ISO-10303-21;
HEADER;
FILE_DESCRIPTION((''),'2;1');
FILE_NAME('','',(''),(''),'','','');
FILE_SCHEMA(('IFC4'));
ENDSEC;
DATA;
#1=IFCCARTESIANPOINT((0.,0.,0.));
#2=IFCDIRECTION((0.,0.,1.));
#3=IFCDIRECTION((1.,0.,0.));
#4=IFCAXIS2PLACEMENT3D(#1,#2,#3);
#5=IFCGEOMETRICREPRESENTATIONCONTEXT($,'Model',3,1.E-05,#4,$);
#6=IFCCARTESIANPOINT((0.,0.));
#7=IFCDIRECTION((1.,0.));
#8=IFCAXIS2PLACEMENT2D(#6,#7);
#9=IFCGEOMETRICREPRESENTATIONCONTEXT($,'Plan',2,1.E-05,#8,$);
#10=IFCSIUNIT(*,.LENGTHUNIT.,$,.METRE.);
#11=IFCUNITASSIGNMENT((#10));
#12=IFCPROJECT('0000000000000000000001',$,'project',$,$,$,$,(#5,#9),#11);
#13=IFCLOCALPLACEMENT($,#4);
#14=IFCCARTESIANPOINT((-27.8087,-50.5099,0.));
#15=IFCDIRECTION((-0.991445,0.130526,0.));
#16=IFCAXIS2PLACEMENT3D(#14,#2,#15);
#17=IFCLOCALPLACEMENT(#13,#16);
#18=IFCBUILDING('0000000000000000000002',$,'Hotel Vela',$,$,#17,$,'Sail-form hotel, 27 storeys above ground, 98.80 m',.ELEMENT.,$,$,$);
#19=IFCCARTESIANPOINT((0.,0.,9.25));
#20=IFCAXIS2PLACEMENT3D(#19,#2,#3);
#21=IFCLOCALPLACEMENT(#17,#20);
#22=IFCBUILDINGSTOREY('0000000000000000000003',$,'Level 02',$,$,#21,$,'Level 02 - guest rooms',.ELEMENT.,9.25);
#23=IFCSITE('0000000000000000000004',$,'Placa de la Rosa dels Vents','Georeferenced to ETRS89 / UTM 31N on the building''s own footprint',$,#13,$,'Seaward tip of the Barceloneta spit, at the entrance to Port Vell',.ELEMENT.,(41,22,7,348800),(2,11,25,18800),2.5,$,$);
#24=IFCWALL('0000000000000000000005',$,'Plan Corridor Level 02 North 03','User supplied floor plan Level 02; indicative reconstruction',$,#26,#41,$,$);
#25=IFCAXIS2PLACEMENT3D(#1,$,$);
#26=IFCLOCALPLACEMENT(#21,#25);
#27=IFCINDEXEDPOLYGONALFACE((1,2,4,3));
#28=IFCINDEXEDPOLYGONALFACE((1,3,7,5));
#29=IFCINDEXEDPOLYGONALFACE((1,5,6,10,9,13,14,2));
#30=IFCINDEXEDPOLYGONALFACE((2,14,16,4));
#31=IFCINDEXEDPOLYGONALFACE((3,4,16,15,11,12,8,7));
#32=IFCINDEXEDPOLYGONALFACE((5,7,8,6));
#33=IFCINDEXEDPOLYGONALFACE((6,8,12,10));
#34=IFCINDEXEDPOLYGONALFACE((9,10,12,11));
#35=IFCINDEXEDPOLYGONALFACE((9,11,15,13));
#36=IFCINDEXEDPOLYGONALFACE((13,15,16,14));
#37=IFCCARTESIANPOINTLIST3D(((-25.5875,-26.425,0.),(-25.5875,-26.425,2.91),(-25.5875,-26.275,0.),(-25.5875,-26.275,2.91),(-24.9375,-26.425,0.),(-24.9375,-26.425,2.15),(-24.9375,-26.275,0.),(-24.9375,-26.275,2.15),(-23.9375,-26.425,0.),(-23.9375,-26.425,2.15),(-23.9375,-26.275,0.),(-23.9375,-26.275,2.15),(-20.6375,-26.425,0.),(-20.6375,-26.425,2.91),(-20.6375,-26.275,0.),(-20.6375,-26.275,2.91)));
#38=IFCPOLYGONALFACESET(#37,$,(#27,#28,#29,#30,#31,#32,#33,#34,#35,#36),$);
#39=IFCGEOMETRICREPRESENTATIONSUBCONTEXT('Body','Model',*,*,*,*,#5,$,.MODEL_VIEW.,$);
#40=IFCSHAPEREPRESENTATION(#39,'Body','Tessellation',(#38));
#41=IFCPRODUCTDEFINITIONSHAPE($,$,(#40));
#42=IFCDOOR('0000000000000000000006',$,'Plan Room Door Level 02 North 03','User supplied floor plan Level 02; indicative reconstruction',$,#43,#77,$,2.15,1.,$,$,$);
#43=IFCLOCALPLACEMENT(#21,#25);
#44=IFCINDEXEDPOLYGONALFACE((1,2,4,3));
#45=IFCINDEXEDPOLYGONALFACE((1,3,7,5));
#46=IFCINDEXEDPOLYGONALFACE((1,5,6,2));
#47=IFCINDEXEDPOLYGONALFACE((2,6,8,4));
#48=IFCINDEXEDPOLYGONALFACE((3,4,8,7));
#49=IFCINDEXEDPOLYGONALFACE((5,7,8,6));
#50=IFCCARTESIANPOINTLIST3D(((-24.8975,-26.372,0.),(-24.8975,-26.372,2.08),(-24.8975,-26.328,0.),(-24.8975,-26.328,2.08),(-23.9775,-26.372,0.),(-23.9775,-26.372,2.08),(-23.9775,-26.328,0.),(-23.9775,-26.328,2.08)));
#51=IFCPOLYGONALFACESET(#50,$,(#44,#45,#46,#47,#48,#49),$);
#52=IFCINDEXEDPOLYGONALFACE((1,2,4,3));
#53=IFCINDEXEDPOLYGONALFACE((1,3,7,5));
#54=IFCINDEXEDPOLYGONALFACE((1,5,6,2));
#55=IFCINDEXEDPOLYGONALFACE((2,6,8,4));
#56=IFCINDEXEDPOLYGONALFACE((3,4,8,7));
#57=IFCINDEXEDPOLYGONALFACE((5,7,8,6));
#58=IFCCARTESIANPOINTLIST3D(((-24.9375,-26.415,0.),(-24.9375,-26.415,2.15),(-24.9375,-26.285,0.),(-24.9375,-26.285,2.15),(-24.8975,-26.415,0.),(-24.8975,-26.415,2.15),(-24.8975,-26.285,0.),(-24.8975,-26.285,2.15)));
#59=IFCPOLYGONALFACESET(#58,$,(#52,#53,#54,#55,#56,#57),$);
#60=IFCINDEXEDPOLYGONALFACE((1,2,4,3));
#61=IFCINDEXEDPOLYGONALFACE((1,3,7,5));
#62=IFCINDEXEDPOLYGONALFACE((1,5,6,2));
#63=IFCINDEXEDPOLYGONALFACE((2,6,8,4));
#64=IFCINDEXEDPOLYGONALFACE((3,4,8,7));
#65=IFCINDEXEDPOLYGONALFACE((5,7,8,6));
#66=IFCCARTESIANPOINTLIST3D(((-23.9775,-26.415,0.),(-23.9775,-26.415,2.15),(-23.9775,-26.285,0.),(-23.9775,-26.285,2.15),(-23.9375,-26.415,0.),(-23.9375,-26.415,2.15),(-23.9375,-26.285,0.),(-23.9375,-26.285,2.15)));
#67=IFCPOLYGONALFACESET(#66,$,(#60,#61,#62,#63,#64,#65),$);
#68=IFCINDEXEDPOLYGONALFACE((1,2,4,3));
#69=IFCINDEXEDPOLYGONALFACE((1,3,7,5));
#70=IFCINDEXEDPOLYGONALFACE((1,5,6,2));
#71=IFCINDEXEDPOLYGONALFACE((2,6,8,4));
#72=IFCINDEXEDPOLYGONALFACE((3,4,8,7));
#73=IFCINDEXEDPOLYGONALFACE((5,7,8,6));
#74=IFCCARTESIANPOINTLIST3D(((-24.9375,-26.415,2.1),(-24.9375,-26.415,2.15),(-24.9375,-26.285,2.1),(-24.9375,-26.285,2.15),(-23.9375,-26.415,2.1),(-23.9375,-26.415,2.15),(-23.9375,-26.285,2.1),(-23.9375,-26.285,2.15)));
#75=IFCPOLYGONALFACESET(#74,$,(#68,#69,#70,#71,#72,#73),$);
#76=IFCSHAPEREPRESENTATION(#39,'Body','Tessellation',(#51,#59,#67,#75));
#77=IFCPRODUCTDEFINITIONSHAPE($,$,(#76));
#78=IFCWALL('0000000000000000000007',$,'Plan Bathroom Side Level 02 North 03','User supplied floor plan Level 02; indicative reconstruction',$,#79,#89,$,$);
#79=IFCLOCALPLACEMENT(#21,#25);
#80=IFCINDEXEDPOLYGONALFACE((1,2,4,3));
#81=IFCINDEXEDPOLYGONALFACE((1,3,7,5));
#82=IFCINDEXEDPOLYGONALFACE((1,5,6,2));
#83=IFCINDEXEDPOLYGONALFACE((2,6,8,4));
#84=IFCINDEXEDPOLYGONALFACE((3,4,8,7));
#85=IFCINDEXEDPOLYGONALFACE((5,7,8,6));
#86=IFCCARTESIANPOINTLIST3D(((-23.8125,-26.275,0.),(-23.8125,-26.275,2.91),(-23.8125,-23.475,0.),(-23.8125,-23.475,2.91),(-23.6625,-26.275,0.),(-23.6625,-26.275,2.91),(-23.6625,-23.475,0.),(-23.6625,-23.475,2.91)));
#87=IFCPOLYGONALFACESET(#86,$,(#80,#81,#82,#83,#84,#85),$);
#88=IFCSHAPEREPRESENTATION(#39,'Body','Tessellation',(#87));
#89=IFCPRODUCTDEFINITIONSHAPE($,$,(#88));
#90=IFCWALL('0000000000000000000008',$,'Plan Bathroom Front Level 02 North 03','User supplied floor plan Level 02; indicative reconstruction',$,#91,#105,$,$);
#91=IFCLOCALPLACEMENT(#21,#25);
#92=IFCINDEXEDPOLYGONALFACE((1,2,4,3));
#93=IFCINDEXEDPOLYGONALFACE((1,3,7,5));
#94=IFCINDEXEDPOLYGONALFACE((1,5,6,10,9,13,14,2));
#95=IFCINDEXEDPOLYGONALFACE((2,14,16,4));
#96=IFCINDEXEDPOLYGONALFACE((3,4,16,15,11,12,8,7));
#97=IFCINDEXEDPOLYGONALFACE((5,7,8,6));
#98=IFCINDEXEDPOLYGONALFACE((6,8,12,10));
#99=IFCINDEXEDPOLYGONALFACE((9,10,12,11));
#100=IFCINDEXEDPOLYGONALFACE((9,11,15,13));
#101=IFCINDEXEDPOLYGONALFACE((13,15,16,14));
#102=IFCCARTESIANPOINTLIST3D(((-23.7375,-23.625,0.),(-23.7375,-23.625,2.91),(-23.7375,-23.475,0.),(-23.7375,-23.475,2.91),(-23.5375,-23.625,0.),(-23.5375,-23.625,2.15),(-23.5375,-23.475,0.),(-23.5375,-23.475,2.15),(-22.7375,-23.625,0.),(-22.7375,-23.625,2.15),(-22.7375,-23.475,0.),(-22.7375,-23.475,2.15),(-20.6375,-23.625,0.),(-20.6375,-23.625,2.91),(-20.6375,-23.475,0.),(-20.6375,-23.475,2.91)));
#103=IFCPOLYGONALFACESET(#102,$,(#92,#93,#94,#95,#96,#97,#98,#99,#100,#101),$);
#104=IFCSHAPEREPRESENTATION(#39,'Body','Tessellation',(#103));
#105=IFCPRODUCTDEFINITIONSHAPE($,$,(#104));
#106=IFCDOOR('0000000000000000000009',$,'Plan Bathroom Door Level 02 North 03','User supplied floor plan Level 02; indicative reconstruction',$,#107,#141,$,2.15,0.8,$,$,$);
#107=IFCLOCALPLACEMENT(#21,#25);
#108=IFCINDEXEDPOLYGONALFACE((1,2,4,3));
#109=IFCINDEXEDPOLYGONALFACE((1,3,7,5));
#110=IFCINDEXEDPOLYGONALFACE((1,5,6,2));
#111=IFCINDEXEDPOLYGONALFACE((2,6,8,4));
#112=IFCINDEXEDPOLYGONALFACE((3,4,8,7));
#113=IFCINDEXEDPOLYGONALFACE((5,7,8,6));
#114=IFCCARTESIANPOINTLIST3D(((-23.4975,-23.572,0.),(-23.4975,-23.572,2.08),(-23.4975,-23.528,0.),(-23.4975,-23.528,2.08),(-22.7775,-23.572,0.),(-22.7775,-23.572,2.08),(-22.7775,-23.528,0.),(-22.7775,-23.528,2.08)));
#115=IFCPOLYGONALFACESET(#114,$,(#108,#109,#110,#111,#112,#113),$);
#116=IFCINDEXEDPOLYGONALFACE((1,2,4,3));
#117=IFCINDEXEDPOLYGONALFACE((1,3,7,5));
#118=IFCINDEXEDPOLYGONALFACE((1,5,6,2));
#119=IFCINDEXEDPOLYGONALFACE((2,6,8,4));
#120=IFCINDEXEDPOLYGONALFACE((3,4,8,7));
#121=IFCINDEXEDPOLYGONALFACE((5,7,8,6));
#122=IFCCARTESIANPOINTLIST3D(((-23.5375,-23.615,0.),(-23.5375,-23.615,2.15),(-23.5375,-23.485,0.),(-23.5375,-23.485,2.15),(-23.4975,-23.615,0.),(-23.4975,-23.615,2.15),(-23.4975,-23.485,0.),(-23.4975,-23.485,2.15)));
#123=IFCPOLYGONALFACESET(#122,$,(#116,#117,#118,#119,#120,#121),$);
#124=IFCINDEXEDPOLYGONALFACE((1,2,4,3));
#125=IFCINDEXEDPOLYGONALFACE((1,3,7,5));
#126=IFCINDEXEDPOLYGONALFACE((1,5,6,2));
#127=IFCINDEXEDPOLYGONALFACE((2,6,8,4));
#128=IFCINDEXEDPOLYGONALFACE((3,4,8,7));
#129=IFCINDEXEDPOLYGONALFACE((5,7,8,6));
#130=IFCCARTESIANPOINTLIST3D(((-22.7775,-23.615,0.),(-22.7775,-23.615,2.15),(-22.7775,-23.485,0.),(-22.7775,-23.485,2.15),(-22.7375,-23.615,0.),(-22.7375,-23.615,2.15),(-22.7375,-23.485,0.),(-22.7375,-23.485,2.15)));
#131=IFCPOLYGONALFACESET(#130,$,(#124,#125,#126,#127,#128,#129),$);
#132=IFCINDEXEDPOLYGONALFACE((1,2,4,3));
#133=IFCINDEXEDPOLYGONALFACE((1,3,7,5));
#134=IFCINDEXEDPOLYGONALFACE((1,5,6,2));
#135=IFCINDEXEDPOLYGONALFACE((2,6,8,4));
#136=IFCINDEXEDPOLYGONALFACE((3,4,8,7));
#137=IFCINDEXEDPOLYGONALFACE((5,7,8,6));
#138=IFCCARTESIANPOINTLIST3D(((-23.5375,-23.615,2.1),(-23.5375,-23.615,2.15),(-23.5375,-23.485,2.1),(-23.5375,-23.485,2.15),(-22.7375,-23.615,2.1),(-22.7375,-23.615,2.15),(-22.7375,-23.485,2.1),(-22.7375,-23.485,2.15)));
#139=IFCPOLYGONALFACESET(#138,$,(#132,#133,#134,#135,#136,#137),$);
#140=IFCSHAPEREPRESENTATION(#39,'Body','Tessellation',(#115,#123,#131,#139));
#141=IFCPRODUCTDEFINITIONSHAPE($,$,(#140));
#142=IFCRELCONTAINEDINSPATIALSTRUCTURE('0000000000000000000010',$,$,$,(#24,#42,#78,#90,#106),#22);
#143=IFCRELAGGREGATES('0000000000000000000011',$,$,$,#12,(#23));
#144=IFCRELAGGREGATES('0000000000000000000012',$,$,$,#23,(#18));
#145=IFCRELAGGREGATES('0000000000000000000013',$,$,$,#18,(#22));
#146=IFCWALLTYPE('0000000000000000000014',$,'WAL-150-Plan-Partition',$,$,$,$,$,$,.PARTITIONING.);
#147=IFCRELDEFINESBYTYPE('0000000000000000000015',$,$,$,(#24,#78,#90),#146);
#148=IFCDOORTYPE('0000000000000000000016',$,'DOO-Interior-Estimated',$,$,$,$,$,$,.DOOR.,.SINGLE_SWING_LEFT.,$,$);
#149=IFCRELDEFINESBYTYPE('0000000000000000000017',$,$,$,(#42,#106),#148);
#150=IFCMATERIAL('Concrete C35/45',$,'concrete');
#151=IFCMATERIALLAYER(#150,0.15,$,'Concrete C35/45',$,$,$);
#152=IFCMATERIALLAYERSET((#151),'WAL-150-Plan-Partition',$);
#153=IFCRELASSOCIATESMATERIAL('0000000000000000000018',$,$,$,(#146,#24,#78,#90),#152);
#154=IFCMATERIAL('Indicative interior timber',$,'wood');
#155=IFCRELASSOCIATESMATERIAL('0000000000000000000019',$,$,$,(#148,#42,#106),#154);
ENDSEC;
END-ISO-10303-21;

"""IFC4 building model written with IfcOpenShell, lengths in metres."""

from ifc_helpers import new_model, si_unit, frame, origin_with_axes, origin_2d_with_axis, place, context, subcontext, project, spatial, line, indexed_curve, outline, extrude, material, layer, layer_set, layer_usage, type_object, element, fill, save


model = new_model("IFC4")

# Units and contexts
model_context = context("Model", 3, precision=1e-05, world=origin_with_axes())
plan_context = context("Plan", 2, precision=1e-05, world=origin_2d_with_axis())
body_context = subcontext(model_context, "Body", "Model", "MODEL_VIEW")
ifc_project = project(units=[si_unit("LENGTHUNIT", "METRE")], contexts=[model_context, plan_context])

# Site, building, storey
site_placement = place(None, origin_with_axes())
site = spatial("IfcSite", under=ifc_project, at=site_placement, Name="Placa de la Rosa dels Vents", Description="Georeferenced to ETRS89 / UTM 31N on the building's own footprint", LongName="Seaward tip of the Barceloneta spit, at the entrance to Port Vell", CompositionType="ELEMENT", RefLatitude=(41, 22, 7, 348800), RefLongitude=(2, 11, 25, 18800), RefElevation=2.5)
building_placement = place(site_placement, frame((-27.8087, -50.5099, 0.0), z_axis=(0.0, 0.0, 1.0), x_axis=(-0.991445, 0.130526, 0.0)))
building = spatial("IfcBuilding", under=site, at=building_placement, Name="Hotel Vela", LongName="Sail-form hotel, 27 storeys above ground, 98.80 m", CompositionType="ELEMENT")
storey_placement = place(building_placement, frame((0.0, 0.0, 9.25), z_axis=(0.0, 0.0, 1.0), x_axis=(1.0, 0.0, 0.0)))
storey = spatial("IfcBuildingStorey", under=building, at=storey_placement, Name="Level 02", LongName="Level 02 - guest rooms", CompositionType="ELEMENT", Elevation=9.25)

# Wall, opening, door
ifc_material_1 = material(Name="Concrete C35/45", Category="concrete")
ifc_layer = layer(ifc_material_1, 0.15, Name="Concrete C35/45")
ifc_layer_set = layer_set([ifc_layer], Name="WAL-150-Plan-Partition")
ifc_layer_usage_1 = layer_usage(ifc_layer_set, "AXIS2", "POSITIVE", 0.0)
wall_type = type_object("IfcWallType", Name="WAL-150-Plan-Partition", PredefinedType="PARTITIONING", material=ifc_layer_set)
wall_1_placement = place(storey_placement, frame((-25.5875, -26.425, 0.0), z_axis=(0.0, 0.0, 1.0), x_axis=(1.0, 0.0, 0.0)))
wall_1 = element("IfcWall", 1, at=wall_1_placement, inside=storey, type_object=wall_type, material=ifc_layer_usage_1, Name="Plan Corridor Level 02 North 03", Description="User supplied floor plan Level 02; indicative reconstruction", context=body_context, shape_type="SweptSolid", body=[
    extrude(outline(indexed_curve([(0.0, 0.0), (4.95, 0.0), (4.95, 0.15), (0.0, 0.15)], segments=[line(1, 2, 3, 4, 1)])), origin_with_axes(), (0.0, 0.0, 1.0), 2.91),
])
opening_1_placement = place(wall_1_placement, frame((0.65, -0.085, 0.0), z_axis=(0.0, 0.0, 1.0), x_axis=(1.0, 0.0, 0.0)))
opening_1 = element("IfcOpeningElement", 2, at=opening_1_placement, cuts=wall_1, PredefinedType="OPENING", context=body_context, shape_type="SweptSolid", body=[
    extrude(outline(indexed_curve([(0.0, 0.0), (1.0, 0.0), (1.0, 0.32), (0.0, 0.32)], segments=[line(1, 2, 3, 4, 1)])), origin_with_axes(), (0.0, 0.0, 1.0), 2.15),
])
ifc_material_2 = material(Name="Indicative interior timber", Category="wood")
door_type = type_object("IfcDoorType", Name="DOO-Interior-Estimated", OperationType="SINGLE_SWING_LEFT", PredefinedType="DOOR", material=ifc_material_2)
door_1_placement = place(storey_placement, frame((0.0, 0.0, -9.25), z_axis=(0.0, 0.0, 1.0), x_axis=(1.0, 0.0, 0.0)))
door_1 = element("IfcDoor", 3, at=door_1_placement, inside=storey, type_object=door_type, material=ifc_material_2, Name="Plan Room Door Level 02 North 03", Description="User supplied floor plan Level 02; indicative reconstruction", OverallHeight=2.15, OverallWidth=1.0, context=body_context, shape_type="SweptSolid", body=[
    extrude(outline(indexed_curve([(0.0, 0.0), (0.92, 0.0), (0.92, 0.044), (0.0, 0.044)], segments=[line(1, 2, 3, 4, 1)])), frame((-24.8975, -26.372, 9.25), z_axis=(0.0, 0.0, 1.0), x_axis=(1.0, 0.0, 0.0)), (0.0, 0.0, 1.0), 2.08),
    extrude(outline(indexed_curve([(0.0, 0.0), (0.04, 0.0), (0.04, 0.13), (0.0, 0.13)], segments=[line(1, 2, 3, 4, 1)])), frame((-24.9375, -26.415, 9.25), z_axis=(0.0, 0.0, 1.0), x_axis=(1.0, 0.0, 0.0)), (0.0, 0.0, 1.0), 2.15),
    extrude(outline(indexed_curve([(0.0, 0.0), (0.04, 0.0), (0.04, 0.13), (0.0, 0.13)], segments=[line(1, 2, 3, 4, 1)])), frame((-23.9775, -26.415, 9.25), z_axis=(0.0, 0.0, 1.0), x_axis=(1.0, 0.0, 0.0)), (0.0, 0.0, 1.0), 2.15),
    extrude(outline(indexed_curve([(0.0, 0.0), (1.0, 0.0), (1.0, 0.13), (0.0, 0.13)], segments=[line(1, 2, 3, 4, 1)])), frame((-24.9375, -26.415, 11.35), z_axis=(0.0, 0.0, 1.0), x_axis=(1.0, 0.0, 0.0)), (0.0, 0.0, 1.0), 0.05),
])
fill(opening_1, door_1)

# Wall
ifc_layer_usage_2 = layer_usage(ifc_layer_set, "AXIS2", "POSITIVE", 0.0)
wall_2_placement = place(storey_placement, frame((-23.8125, -26.275, 0.0), z_axis=(0.0, 0.0, 1.0), x_axis=(1.0, 0.0, 0.0)))
element("IfcWall", 4, at=wall_2_placement, inside=storey, type_object=wall_type, material=ifc_layer_usage_2, Name="Plan Bathroom Side Level 02 North 03", Description="User supplied floor plan Level 02; indicative reconstruction", context=body_context, shape_type="SweptSolid", body=[
    extrude(outline(indexed_curve([(0.0, 0.0), (0.15, 0.0), (0.15, 2.8), (0.0, 2.8)], segments=[line(1, 2, 3, 4, 1)])), origin_with_axes(), (0.0, 0.0, 1.0), 2.91),
])

# Wall, opening, door
ifc_layer_usage_3 = layer_usage(ifc_layer_set, "AXIS2", "POSITIVE", 0.0)
wall_3_placement = place(storey_placement, frame((-23.7375, -23.625, 0.0), z_axis=(0.0, 0.0, 1.0), x_axis=(1.0, 0.0, 0.0)))
wall_3 = element("IfcWall", 5, at=wall_3_placement, inside=storey, type_object=wall_type, material=ifc_layer_usage_3, Name="Plan Bathroom Front Level 02 North 03", Description="User supplied floor plan Level 02; indicative reconstruction", context=body_context, shape_type="SweptSolid", body=[
    extrude(outline(indexed_curve([(0.0, 0.0), (3.1, 0.0), (3.1, 0.15), (0.0, 0.15)], segments=[line(1, 2, 3, 4, 1)])), origin_with_axes(), (0.0, 0.0, 1.0), 2.91),
])
opening_2_placement = place(wall_3_placement, frame((0.2, -0.085, 0.0), z_axis=(0.0, 0.0, 1.0), x_axis=(1.0, 0.0, 0.0)))
opening_2 = element("IfcOpeningElement", 6, at=opening_2_placement, cuts=wall_3, PredefinedType="OPENING", context=body_context, shape_type="SweptSolid", body=[
    extrude(outline(indexed_curve([(0.0, 0.0), (0.8, 0.0), (0.8, 0.32), (0.0, 0.32)], segments=[line(1, 2, 3, 4, 1)])), origin_with_axes(), (0.0, 0.0, 1.0), 2.15),
])
door_2_placement = place(storey_placement, frame((0.0, 0.0, -9.25), z_axis=(0.0, 0.0, 1.0), x_axis=(1.0, 0.0, 0.0)))
door_2 = element("IfcDoor", 7, at=door_2_placement, inside=storey, type_object=door_type, material=ifc_material_2, Name="Plan Bathroom Door Level 02 North 03", Description="User supplied floor plan Level 02; indicative reconstruction", OverallHeight=2.15, OverallWidth=0.8, context=body_context, shape_type="SweptSolid", body=[
    extrude(outline(indexed_curve([(0.0, 0.0), (0.72, 0.0), (0.72, 0.044), (0.0, 0.044)], segments=[line(1, 2, 3, 4, 1)])), frame((-23.4975, -23.572, 9.25), z_axis=(0.0, 0.0, 1.0), x_axis=(1.0, 0.0, 0.0)), (0.0, 0.0, 1.0), 2.08),
    extrude(outline(indexed_curve([(0.0, 0.0), (0.04, 0.0), (0.04, 0.13), (0.0, 0.13)], segments=[line(1, 2, 3, 4, 1)])), frame((-23.5375, -23.615, 9.25), z_axis=(0.0, 0.0, 1.0), x_axis=(1.0, 0.0, 0.0)), (0.0, 0.0, 1.0), 2.15),
    extrude(outline(indexed_curve([(0.0, 0.0), (0.04, 0.0), (0.04, 0.13), (0.0, 0.13)], segments=[line(1, 2, 3, 4, 1)])), frame((-22.7775, -23.615, 9.25), z_axis=(0.0, 0.0, 1.0), x_axis=(1.0, 0.0, 0.0)), (0.0, 0.0, 1.0), 2.15),
    extrude(outline(indexed_curve([(0.0, 0.0), (0.8, 0.0), (0.8, 0.13), (0.0, 0.13)], segments=[line(1, 2, 3, 4, 1)])), frame((-23.5375, -23.615, 11.35), z_axis=(0.0, 0.0, 1.0), x_axis=(1.0, 0.0, 0.0)), (0.0, 0.0, 1.0), 0.05),
])
fill(opening_2, door_2)

save(model, "model.ifc")
